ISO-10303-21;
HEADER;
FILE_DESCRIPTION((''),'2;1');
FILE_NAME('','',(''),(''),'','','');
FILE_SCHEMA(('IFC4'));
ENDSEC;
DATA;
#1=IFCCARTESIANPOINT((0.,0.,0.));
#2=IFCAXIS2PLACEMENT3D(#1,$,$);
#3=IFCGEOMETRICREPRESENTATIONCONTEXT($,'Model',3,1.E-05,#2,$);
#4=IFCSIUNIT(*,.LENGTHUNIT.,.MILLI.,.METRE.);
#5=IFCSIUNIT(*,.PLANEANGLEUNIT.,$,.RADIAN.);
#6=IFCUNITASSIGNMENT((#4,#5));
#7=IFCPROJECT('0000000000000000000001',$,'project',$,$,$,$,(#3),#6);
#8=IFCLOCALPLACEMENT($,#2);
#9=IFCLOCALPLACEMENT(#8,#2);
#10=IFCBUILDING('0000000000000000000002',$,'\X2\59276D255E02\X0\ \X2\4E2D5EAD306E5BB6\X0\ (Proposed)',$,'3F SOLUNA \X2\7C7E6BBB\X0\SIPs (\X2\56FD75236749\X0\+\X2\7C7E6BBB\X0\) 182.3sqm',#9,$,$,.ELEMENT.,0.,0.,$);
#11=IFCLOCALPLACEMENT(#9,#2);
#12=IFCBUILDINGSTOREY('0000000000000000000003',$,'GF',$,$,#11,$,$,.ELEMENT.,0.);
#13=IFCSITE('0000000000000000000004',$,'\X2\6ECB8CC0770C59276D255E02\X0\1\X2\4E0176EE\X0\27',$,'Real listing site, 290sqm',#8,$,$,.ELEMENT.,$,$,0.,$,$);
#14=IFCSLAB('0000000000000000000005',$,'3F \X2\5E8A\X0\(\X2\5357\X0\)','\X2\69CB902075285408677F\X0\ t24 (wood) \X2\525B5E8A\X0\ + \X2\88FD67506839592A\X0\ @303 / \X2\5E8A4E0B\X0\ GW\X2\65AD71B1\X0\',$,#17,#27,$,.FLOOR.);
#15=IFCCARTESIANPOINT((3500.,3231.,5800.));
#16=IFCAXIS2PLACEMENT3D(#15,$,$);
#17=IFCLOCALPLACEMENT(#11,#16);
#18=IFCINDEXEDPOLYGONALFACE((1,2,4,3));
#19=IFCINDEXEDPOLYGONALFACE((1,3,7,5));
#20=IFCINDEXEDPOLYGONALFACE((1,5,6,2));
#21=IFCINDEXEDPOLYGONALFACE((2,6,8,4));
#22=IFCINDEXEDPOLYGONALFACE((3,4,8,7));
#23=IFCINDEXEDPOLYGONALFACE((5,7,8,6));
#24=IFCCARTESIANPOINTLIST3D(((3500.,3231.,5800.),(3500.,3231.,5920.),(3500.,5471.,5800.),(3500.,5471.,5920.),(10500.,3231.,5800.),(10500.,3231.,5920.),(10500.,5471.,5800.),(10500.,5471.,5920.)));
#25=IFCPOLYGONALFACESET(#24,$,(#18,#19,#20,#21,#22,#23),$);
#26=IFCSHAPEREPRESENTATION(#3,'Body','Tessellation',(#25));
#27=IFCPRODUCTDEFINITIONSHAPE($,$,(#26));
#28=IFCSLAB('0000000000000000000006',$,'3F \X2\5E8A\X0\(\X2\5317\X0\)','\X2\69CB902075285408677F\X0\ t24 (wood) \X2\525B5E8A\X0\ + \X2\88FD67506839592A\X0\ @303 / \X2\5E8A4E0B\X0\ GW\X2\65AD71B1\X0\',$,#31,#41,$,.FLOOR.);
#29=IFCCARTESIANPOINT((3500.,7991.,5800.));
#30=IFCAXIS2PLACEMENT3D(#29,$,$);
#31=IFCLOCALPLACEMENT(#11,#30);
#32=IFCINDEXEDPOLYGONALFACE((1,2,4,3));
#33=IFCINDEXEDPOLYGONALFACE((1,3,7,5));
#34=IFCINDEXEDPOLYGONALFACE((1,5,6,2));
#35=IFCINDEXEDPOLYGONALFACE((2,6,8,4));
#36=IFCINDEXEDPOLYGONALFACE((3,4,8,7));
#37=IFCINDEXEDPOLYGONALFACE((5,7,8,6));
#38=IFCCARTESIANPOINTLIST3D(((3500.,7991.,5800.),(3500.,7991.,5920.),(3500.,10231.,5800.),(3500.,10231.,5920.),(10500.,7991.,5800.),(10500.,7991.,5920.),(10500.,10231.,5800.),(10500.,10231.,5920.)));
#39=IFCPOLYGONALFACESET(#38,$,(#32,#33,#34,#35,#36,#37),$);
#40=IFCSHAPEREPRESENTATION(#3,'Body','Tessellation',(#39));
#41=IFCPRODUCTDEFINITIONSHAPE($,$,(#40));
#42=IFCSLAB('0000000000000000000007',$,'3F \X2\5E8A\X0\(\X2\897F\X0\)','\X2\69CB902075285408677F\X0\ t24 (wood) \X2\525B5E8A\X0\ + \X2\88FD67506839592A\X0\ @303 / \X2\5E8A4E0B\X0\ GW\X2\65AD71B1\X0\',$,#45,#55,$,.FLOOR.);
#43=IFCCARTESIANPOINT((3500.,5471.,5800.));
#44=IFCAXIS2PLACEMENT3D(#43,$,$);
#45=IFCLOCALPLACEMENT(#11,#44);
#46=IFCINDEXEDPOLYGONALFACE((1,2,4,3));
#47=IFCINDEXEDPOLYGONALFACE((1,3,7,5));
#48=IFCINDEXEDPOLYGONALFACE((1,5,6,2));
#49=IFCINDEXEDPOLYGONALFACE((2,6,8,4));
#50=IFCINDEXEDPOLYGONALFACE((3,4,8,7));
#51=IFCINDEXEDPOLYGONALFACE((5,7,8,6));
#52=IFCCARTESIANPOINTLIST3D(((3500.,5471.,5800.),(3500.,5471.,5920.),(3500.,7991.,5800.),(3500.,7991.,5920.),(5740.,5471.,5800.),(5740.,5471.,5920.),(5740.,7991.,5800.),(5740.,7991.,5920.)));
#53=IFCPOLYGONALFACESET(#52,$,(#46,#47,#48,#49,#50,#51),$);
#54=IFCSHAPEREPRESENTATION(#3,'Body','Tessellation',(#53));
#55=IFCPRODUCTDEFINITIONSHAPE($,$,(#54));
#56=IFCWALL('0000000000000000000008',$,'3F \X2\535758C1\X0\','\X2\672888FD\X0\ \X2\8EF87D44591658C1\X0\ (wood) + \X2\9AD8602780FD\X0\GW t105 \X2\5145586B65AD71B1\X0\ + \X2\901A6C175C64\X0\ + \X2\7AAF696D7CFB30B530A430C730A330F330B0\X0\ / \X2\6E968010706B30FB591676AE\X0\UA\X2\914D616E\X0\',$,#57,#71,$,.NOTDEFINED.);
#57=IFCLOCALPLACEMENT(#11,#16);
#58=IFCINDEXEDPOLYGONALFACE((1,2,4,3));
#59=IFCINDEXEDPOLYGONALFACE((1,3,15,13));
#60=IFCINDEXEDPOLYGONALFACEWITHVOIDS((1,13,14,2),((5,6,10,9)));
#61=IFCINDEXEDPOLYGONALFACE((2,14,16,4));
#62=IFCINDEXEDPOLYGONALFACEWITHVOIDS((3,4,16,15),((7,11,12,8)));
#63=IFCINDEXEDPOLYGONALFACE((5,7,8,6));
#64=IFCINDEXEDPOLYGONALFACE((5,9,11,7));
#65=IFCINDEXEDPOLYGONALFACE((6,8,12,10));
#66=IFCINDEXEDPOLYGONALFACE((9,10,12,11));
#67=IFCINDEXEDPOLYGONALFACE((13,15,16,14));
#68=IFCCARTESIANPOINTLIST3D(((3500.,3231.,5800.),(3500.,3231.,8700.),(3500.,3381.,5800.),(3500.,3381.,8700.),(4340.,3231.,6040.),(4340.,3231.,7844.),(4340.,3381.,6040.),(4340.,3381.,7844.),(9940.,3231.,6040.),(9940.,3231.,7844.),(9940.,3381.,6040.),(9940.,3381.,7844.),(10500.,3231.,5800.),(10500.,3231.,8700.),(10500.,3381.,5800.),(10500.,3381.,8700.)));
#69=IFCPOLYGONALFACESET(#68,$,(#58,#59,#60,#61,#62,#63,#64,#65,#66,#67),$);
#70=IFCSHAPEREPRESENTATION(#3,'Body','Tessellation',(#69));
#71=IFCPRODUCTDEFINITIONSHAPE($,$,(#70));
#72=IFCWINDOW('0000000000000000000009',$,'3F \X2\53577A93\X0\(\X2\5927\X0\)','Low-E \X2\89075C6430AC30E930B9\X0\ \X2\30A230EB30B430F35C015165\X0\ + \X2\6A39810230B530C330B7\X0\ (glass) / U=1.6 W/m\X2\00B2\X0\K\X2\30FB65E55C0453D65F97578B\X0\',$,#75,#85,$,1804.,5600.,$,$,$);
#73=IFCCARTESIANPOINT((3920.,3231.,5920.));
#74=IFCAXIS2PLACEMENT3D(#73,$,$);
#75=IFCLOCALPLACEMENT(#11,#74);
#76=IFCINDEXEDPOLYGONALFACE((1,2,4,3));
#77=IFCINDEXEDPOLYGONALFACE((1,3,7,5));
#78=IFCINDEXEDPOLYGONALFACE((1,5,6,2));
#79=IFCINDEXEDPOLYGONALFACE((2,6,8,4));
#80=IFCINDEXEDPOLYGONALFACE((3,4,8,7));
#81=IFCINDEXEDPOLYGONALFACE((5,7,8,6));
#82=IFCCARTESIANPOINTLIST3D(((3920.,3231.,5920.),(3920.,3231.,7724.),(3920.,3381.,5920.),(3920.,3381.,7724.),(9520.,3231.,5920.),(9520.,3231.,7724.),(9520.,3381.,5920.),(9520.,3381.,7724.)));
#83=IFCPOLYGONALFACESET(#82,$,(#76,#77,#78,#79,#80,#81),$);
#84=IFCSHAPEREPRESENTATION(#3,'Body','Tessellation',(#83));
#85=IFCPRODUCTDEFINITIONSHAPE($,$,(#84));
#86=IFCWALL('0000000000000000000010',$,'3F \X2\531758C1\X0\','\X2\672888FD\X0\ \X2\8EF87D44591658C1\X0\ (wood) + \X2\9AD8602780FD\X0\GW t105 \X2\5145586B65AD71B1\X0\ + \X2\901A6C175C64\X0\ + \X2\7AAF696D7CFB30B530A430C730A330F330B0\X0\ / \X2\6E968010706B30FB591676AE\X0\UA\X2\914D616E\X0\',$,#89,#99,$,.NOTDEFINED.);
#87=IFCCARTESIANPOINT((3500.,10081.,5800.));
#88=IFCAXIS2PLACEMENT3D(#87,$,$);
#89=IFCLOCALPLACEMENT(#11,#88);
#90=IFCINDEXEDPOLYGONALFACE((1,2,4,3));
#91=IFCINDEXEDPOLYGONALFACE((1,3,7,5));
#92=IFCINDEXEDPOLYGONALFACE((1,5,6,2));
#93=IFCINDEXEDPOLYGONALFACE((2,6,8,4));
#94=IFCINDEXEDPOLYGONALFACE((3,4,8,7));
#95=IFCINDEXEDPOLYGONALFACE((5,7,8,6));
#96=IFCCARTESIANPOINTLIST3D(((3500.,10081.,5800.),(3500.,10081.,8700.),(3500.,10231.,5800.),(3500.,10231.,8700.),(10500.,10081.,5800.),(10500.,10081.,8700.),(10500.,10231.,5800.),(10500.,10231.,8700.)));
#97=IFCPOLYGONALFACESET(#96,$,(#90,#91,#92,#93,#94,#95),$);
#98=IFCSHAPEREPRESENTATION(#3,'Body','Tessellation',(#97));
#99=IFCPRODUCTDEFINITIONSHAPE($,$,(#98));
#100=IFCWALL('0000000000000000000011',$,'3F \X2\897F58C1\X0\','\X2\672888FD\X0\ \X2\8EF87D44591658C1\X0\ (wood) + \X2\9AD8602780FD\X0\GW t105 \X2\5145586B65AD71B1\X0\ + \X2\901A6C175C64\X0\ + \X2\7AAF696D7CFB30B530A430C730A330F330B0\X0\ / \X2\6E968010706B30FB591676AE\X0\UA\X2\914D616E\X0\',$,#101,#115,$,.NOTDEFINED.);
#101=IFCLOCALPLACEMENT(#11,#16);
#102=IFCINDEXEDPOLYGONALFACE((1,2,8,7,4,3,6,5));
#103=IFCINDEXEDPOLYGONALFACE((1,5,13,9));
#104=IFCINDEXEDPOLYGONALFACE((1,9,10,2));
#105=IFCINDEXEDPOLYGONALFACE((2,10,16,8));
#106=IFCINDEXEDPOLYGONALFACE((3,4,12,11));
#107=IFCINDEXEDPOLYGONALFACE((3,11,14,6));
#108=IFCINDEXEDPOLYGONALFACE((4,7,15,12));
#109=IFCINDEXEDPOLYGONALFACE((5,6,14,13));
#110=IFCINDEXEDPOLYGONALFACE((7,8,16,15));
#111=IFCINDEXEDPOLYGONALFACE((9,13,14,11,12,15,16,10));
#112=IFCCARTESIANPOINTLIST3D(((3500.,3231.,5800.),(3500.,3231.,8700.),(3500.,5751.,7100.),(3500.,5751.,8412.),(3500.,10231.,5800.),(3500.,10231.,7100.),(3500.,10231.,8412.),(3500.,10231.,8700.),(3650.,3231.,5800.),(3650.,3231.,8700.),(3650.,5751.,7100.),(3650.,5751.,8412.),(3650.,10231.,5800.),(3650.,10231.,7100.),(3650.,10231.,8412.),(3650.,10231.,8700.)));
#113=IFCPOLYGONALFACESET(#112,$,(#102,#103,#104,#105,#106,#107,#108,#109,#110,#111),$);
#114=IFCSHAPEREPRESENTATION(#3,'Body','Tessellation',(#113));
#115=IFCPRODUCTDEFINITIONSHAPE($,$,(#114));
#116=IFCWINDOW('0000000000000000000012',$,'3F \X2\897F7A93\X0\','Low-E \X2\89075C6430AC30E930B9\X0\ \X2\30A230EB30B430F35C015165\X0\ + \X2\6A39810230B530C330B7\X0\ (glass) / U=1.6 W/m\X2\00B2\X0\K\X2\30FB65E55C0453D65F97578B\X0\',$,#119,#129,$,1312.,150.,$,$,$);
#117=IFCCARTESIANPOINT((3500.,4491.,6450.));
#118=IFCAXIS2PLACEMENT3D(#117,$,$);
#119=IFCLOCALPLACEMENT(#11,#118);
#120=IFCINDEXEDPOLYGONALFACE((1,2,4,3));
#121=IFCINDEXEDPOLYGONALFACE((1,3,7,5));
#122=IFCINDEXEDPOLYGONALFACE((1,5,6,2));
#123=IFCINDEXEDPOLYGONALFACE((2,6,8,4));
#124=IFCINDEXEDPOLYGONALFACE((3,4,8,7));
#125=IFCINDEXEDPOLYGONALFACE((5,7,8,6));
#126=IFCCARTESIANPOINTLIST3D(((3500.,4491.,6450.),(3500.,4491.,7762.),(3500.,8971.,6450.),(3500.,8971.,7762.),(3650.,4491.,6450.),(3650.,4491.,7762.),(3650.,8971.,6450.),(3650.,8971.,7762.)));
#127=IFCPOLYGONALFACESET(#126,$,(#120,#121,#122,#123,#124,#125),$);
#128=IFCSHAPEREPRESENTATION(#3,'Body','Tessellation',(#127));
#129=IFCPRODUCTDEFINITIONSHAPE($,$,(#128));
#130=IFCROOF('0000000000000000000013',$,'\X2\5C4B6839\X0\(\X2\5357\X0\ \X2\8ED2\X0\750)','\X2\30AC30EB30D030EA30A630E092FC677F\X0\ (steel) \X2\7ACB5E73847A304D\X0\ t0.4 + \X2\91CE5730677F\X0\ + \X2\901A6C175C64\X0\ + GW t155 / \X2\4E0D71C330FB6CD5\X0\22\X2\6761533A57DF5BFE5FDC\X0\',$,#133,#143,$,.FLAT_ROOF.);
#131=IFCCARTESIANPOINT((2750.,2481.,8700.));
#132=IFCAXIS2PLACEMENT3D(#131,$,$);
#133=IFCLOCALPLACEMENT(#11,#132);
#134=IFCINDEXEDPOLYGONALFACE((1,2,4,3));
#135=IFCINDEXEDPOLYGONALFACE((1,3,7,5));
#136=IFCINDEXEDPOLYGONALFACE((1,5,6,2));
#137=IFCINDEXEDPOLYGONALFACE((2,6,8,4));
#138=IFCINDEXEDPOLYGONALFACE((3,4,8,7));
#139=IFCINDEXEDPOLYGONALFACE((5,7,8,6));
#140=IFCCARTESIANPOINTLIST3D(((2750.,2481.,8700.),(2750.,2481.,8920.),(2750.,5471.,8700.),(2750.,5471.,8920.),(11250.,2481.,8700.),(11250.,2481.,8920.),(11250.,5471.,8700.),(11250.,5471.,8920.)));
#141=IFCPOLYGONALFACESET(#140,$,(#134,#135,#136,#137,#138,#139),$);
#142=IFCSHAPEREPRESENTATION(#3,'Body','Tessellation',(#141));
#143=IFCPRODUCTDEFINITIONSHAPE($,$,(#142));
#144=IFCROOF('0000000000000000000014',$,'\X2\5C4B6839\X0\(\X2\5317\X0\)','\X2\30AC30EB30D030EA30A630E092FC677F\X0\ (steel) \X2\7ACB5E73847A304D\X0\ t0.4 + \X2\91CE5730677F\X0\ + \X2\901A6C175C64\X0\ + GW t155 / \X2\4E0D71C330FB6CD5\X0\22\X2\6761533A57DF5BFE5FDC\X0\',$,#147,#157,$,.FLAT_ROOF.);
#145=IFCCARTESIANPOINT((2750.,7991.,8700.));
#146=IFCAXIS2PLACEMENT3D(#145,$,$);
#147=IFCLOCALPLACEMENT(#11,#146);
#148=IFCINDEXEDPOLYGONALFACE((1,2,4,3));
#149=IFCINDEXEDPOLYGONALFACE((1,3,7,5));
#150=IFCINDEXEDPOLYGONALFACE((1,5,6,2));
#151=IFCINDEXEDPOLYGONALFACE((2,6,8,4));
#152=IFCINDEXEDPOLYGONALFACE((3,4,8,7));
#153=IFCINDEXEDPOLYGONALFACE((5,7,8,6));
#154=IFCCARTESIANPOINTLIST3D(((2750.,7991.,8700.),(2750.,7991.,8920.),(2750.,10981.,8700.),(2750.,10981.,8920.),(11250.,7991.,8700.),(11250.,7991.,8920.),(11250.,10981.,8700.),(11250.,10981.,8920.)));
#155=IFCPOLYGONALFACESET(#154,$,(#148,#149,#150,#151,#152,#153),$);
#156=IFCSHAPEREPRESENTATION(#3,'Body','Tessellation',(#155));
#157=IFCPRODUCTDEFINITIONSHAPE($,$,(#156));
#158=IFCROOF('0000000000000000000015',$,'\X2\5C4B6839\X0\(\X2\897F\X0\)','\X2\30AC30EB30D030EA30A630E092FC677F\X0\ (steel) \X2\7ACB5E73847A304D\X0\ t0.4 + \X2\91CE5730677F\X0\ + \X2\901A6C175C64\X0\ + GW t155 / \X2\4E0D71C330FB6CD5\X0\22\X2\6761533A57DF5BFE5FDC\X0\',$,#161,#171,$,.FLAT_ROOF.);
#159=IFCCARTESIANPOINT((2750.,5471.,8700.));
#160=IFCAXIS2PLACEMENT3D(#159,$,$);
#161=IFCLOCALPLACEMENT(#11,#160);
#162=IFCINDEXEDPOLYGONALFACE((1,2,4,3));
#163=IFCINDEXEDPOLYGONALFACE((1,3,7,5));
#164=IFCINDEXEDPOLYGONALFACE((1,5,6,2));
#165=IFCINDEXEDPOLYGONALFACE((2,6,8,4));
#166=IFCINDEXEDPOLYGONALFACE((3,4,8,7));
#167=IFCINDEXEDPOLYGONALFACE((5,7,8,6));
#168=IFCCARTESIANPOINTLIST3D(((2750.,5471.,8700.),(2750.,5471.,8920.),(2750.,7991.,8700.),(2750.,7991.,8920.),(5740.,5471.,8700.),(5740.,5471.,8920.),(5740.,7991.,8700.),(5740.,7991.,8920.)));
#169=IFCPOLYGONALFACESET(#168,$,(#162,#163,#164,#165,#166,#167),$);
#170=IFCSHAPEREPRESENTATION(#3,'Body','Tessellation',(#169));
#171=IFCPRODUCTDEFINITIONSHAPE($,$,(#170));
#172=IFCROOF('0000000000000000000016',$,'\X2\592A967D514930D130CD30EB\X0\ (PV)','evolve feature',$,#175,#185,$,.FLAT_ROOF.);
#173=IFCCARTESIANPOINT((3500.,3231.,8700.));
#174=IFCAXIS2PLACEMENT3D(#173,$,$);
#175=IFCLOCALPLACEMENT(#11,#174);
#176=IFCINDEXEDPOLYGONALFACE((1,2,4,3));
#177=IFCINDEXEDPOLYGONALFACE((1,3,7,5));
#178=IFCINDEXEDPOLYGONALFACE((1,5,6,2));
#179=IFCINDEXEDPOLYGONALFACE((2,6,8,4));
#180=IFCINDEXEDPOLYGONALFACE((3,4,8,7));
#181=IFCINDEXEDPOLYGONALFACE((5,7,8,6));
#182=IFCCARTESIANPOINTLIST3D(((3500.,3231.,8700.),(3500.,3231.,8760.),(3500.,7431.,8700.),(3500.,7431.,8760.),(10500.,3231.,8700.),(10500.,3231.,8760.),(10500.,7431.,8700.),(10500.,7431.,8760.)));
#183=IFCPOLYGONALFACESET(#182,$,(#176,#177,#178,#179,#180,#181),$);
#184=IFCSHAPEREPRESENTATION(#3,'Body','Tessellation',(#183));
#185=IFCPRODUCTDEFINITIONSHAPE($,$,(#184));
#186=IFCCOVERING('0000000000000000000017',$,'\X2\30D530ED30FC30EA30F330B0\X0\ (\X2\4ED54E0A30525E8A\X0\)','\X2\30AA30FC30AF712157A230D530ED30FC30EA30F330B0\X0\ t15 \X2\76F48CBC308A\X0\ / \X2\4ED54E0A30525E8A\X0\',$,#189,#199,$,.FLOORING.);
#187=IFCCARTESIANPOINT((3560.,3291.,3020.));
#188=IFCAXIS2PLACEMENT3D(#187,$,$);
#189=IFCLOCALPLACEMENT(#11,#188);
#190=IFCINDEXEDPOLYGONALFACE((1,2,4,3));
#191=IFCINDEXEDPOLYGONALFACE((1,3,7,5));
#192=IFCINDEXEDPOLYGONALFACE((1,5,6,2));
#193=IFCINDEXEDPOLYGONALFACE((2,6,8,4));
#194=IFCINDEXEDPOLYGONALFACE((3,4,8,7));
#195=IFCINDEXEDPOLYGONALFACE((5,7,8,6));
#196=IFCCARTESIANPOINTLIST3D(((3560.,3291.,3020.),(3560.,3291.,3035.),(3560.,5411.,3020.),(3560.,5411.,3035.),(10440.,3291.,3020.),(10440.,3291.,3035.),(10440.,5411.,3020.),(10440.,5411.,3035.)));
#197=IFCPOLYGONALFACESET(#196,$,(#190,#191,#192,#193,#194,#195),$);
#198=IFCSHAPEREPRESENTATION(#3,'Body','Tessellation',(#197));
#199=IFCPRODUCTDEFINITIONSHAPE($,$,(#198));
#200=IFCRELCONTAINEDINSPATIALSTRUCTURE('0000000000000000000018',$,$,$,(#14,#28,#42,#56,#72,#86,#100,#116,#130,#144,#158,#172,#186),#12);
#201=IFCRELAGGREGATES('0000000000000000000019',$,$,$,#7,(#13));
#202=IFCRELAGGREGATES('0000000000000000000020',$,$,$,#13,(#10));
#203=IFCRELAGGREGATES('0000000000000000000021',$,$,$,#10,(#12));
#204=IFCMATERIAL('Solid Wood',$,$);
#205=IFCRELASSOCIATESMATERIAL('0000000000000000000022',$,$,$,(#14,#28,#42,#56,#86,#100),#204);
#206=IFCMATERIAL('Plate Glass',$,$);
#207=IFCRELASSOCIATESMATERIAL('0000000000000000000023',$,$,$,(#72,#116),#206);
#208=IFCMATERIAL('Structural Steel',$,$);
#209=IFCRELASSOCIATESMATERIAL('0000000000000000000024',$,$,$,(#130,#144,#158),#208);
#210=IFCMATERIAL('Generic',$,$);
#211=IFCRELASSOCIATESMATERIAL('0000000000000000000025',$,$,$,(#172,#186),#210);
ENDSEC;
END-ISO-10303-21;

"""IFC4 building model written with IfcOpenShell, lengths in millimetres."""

from ifc_helpers import new_model, si_unit, frame, frame_2d, origin, place, context, project, spatial, rectangle, extrude, material, element, fill, save


model = new_model("IFC4")

# Units and contexts
model_context = context("Model", 3, precision=1e-05, world=origin())
ifc_project = project(units=[si_unit("LENGTHUNIT", "METRE", prefix="MILLI"), si_unit("PLANEANGLEUNIT", "RADIAN")], contexts=[model_context])

# Site, building, storey
site_placement = place(None, origin())
site = spatial("IfcSite", under=ifc_project, at=site_placement, Name="滋賀県大津市1丁目27", ObjectType="Real listing site, 290sqm", CompositionType="ELEMENT", RefElevation=0.0)
building_placement = place(site_placement, origin())
building = spatial("IfcBuilding", under=site, at=building_placement, Name="大津市 中庭の家 (Proposed)", ObjectType="3F SOLUNA 籾殻SIPs (国産杉+籾殻) 182.3sqm", CompositionType="ELEMENT", ElevationOfRefHeight=0.0, ElevationOfTerrain=0.0)
storey_placement = place(building_placement, origin())
storey = spatial("IfcBuildingStorey", under=building, at=storey_placement, Name="GF", CompositionType="ELEMENT", Elevation=0.0)

# Slabs
ifc_material_1 = material(Name="Solid Wood")
slab_1_placement = place(storey_placement, frame((3500.0, 3231.0, 5800.0)))
element("IfcSlab", 1, at=slab_1_placement, inside=storey, material=ifc_material_1, Name="3F 床(南)", Description="構造用合板 t24 (wood) 剛床 + 製材根太 @303 / 床下 GW断熱", PredefinedType="FLOOR", context=model_context, shape_type="SweptSolid", body=[
    extrude(rectangle(XDim=7000.0, YDim=2240.0, at=frame_2d((3500.0, 1120.0))), frame((3500.0, 3231.0, 5800.0)), (0.0, 0.0, 1.0), 120.0),
])
slab_2_placement = place(storey_placement, frame((3500.0, 7991.0, 5800.0)))
element("IfcSlab", 2, at=slab_2_placement, inside=storey, material=ifc_material_1, Name="3F 床(北)", Description="構造用合板 t24 (wood) 剛床 + 製材根太 @303 / 床下 GW断熱", PredefinedType="FLOOR", context=model_context, shape_type="SweptSolid", body=[
    extrude(rectangle(XDim=7000.0, YDim=2240.0, at=frame_2d((3500.0, 1120.0))), frame((3500.0, 7991.0, 5800.0)), (0.0, 0.0, 1.0), 120.0),
])
slab_3_placement = place(storey_placement, frame((3500.0, 5471.0, 5800.0)))
element("IfcSlab", 3, at=slab_3_placement, inside=storey, material=ifc_material_1, Name="3F 床(西)", Description="構造用合板 t24 (wood) 剛床 + 製材根太 @303 / 床下 GW断熱", PredefinedType="FLOOR", context=model_context, shape_type="SweptSolid", body=[
    extrude(rectangle(XDim=2240.0, YDim=2520.0, at=frame_2d((1120.0, 1260.0))), frame((3500.0, 5471.0, 5800.0)), (0.0, 0.0, 1.0), 120.0),
])

# Wall, opening, window
wall_1_placement = place(storey_placement, frame((3500.0, 3231.0, 5800.0)))
wall_1 = element("IfcWall", 4, at=wall_1_placement, inside=storey, material=ifc_material_1, Name="3F 南壁", Description="木製 軸組外壁 (wood) + 高性能GW t105 充填断熱 + 通気層 + 窯業系サイディング / 準耐火・外皮UA配慮", PredefinedType="NOTDEFINED", context=model_context, shape_type="SweptSolid", body=[
    extrude(rectangle(XDim=7000.0, YDim=150.0, at=frame_2d((3500.0, 75.0))), frame((3500.0, 3231.0, 5800.0)), (0.0, 0.0, 1.0), 2900.0),
])
opening_1_placement = place(storey_placement, frame((3920.0, 3231.0, 5920.0)))
opening_1 = element("IfcOpeningElement", 5, at=opening_1_placement, cuts=wall_1, PredefinedType="NOTDEFINED", context=model_context, shape_type="SweptSolid", body=[
    extrude(rectangle(XDim=5600.0, YDim=150.0, at=frame_2d((2800.0, 75.0))), frame((3920.0, 3231.0, 5920.0)), (0.0, 0.0, 1.0), 1804.0),
])
ifc_material_2 = material(Name="Plate Glass")
window_1_placement = place(storey_placement, frame((3920.0, 3231.0, 5920.0)))
window_1 = element("IfcWindow", 6, at=window_1_placement, inside=storey, material=ifc_material_2, Name="3F 南窓(大)", Description="Low-E 複層ガラス アルゴン封入 + 樹脂サッシ (glass) / U=1.6 W/m²K・日射取得型", OverallHeight=1804.0, OverallWidth=5600.0, context=model_context, shape_type="SweptSolid", body=[
    extrude(rectangle(XDim=5600.0, YDim=150.0, at=frame_2d((2800.0, 75.0))), frame((3920.0, 3231.0, 5920.0)), (0.0, 0.0, 1.0), 1804.0),
])
fill(opening_1, window_1)

# Wall
wall_2_placement = place(storey_placement, frame((3500.0, 10081.0, 5800.0)))
element("IfcWall", 7, at=wall_2_placement, inside=storey, material=ifc_material_1, Name="3F 北壁", Description="木製 軸組外壁 (wood) + 高性能GW t105 充填断熱 + 通気層 + 窯業系サイディング / 準耐火・外皮UA配慮", PredefinedType="NOTDEFINED", context=model_context, shape_type="SweptSolid", body=[
    extrude(rectangle(XDim=7000.0, YDim=150.0, at=frame_2d((3500.0, 75.0))), frame((3500.0, 10081.0, 5800.0)), (0.0, 0.0, 1.0), 2900.0),
])

# Wall, opening, window
wall_3_placement = place(storey_placement, frame((3500.0, 3231.0, 5800.0)))
wall_3 = element("IfcWall", 8, at=wall_3_placement, inside=storey, material=ifc_material_1, Name="3F 西壁", Description="木製 軸組外壁 (wood) + 高性能GW t105 充填断熱 + 通気層 + 窯業系サイディング / 準耐火・外皮UA配慮", PredefinedType="NOTDEFINED", context=model_context, shape_type="SweptSolid", body=[
    extrude(rectangle(XDim=150.0, YDim=7000.0, at=frame_2d((75.0, 3500.0))), frame((3500.0, 3231.0, 5800.0)), (0.0, 0.0, 1.0), 2900.0),
])
opening_2_placement = place(storey_placement, frame((3500.0, 4491.0, 6450.0)))
opening_2 = element("IfcOpeningElement", 9, at=opening_2_placement, cuts=wall_3, PredefinedType="NOTDEFINED", context=model_context, shape_type="SweptSolid", body=[
    extrude(rectangle(XDim=150.0, YDim=4480.0, at=frame_2d((75.0, 2240.0))), frame((3500.0, 4491.0, 6450.0)), (0.0, 0.0, 1.0), 1312.0),
])
window_2_placement = place(storey_placement, frame((3500.0, 4491.0, 6450.0)))
window_2 = element("IfcWindow", 10, at=window_2_placement, inside=storey, material=ifc_material_2, Name="3F 西窓", Description="Low-E 複層ガラス アルゴン封入 + 樹脂サッシ (glass) / U=1.6 W/m²K・日射取得型", OverallHeight=1312.0, OverallWidth=150.0, context=model_context, shape_type="SweptSolid", body=[
    extrude(rectangle(XDim=150.0, YDim=4480.0, at=frame_2d((75.0, 2240.0))), frame((3500.0, 4491.0, 6450.0)), (0.0, 0.0, 1.0), 1312.0),
])
fill(opening_2, window_2)

# Roofs
ifc_material_3 = material(Name="Structural Steel")
roof_1_placement = place(storey_placement, frame((2750.0, 2481.0, 8700.0)))
element("IfcRoof", 11, at=roof_1_placement, inside=storey, material=ifc_material_3, Name="屋根(南 軒750)", Description="ガルバリウム鋼板 (steel) 立平葺き t0.4 + 野地板 + 通気層 + GW t155 / 不燃・法22条区域対応", PredefinedType="FLAT_ROOF", context=model_context, shape_type="SweptSolid", body=[
    extrude(rectangle(XDim=8500.0, YDim=2990.0, at=frame_2d((4250.0, 1495.0))), frame((2750.0, 2481.0, 8700.0)), (0.0, 0.0, 1.0), 220.0),
])
roof_2_placement = place(storey_placement, frame((2750.0, 7991.0, 8700.0)))
element("IfcRoof", 12, at=roof_2_placement, inside=storey, material=ifc_material_3, Name="屋根(北)", Description="ガルバリウム鋼板 (steel) 立平葺き t0.4 + 野地板 + 通気層 + GW t155 / 不燃・法22条区域対応", PredefinedType="FLAT_ROOF", context=model_context, shape_type="SweptSolid", body=[
    extrude(rectangle(XDim=8500.0, YDim=2990.0, at=frame_2d((4250.0, 1495.0))), frame((2750.0, 7991.0, 8700.0)), (0.0, 0.0, 1.0), 220.0),
])
roof_3_placement = place(storey_placement, frame((2750.0, 5471.0, 8700.0)))
element("IfcRoof", 13, at=roof_3_placement, inside=storey, material=ifc_material_3, Name="屋根(西)", Description="ガルバリウム鋼板 (steel) 立平葺き t0.4 + 野地板 + 通気層 + GW t155 / 不燃・法22条区域対応", PredefinedType="FLAT_ROOF", context=model_context, shape_type="SweptSolid", body=[
    extrude(rectangle(XDim=2990.0, YDim=2520.0, at=frame_2d((1495.0, 1260.0))), frame((2750.0, 5471.0, 8700.0)), (0.0, 0.0, 1.0), 220.0),
])
ifc_material_4 = material(Name="Generic")
roof_4_placement = place(storey_placement, frame((3500.0, 3231.0, 8700.0)))
element("IfcRoof", 14, at=roof_4_placement, inside=storey, material=ifc_material_4, Name="太陽光パネル (PV)", Description="evolve feature", PredefinedType="FLAT_ROOF", context=model_context, shape_type="SweptSolid", body=[
    extrude(rectangle(XDim=7000.0, YDim=4200.0, at=frame_2d((3500.0, 2100.0))), frame((3500.0, 3231.0, 8700.0)), (0.0, 0.0, 1.0), 60.0),
])

# Covering
covering_1_placement = place(storey_placement, frame((3560.0, 3291.0, 3020.0)))
element("IfcCovering", 15, at=covering_1_placement, inside=storey, material=ifc_material_4, Name="フローリング (仕上げ床)", Description="オーク無垢フローリング t15 直貼り / 仕上げ床", PredefinedType="FLOORING", context=model_context, shape_type="SweptSolid", body=[
    extrude(rectangle(XDim=6880.0, YDim=2120.0, at=frame_2d((3440.0, 1060.0))), frame((3560.0, 3291.0, 3020.0)), (0.0, 0.0, 1.0), 15.0),
])

save(model, "model.ifc")
